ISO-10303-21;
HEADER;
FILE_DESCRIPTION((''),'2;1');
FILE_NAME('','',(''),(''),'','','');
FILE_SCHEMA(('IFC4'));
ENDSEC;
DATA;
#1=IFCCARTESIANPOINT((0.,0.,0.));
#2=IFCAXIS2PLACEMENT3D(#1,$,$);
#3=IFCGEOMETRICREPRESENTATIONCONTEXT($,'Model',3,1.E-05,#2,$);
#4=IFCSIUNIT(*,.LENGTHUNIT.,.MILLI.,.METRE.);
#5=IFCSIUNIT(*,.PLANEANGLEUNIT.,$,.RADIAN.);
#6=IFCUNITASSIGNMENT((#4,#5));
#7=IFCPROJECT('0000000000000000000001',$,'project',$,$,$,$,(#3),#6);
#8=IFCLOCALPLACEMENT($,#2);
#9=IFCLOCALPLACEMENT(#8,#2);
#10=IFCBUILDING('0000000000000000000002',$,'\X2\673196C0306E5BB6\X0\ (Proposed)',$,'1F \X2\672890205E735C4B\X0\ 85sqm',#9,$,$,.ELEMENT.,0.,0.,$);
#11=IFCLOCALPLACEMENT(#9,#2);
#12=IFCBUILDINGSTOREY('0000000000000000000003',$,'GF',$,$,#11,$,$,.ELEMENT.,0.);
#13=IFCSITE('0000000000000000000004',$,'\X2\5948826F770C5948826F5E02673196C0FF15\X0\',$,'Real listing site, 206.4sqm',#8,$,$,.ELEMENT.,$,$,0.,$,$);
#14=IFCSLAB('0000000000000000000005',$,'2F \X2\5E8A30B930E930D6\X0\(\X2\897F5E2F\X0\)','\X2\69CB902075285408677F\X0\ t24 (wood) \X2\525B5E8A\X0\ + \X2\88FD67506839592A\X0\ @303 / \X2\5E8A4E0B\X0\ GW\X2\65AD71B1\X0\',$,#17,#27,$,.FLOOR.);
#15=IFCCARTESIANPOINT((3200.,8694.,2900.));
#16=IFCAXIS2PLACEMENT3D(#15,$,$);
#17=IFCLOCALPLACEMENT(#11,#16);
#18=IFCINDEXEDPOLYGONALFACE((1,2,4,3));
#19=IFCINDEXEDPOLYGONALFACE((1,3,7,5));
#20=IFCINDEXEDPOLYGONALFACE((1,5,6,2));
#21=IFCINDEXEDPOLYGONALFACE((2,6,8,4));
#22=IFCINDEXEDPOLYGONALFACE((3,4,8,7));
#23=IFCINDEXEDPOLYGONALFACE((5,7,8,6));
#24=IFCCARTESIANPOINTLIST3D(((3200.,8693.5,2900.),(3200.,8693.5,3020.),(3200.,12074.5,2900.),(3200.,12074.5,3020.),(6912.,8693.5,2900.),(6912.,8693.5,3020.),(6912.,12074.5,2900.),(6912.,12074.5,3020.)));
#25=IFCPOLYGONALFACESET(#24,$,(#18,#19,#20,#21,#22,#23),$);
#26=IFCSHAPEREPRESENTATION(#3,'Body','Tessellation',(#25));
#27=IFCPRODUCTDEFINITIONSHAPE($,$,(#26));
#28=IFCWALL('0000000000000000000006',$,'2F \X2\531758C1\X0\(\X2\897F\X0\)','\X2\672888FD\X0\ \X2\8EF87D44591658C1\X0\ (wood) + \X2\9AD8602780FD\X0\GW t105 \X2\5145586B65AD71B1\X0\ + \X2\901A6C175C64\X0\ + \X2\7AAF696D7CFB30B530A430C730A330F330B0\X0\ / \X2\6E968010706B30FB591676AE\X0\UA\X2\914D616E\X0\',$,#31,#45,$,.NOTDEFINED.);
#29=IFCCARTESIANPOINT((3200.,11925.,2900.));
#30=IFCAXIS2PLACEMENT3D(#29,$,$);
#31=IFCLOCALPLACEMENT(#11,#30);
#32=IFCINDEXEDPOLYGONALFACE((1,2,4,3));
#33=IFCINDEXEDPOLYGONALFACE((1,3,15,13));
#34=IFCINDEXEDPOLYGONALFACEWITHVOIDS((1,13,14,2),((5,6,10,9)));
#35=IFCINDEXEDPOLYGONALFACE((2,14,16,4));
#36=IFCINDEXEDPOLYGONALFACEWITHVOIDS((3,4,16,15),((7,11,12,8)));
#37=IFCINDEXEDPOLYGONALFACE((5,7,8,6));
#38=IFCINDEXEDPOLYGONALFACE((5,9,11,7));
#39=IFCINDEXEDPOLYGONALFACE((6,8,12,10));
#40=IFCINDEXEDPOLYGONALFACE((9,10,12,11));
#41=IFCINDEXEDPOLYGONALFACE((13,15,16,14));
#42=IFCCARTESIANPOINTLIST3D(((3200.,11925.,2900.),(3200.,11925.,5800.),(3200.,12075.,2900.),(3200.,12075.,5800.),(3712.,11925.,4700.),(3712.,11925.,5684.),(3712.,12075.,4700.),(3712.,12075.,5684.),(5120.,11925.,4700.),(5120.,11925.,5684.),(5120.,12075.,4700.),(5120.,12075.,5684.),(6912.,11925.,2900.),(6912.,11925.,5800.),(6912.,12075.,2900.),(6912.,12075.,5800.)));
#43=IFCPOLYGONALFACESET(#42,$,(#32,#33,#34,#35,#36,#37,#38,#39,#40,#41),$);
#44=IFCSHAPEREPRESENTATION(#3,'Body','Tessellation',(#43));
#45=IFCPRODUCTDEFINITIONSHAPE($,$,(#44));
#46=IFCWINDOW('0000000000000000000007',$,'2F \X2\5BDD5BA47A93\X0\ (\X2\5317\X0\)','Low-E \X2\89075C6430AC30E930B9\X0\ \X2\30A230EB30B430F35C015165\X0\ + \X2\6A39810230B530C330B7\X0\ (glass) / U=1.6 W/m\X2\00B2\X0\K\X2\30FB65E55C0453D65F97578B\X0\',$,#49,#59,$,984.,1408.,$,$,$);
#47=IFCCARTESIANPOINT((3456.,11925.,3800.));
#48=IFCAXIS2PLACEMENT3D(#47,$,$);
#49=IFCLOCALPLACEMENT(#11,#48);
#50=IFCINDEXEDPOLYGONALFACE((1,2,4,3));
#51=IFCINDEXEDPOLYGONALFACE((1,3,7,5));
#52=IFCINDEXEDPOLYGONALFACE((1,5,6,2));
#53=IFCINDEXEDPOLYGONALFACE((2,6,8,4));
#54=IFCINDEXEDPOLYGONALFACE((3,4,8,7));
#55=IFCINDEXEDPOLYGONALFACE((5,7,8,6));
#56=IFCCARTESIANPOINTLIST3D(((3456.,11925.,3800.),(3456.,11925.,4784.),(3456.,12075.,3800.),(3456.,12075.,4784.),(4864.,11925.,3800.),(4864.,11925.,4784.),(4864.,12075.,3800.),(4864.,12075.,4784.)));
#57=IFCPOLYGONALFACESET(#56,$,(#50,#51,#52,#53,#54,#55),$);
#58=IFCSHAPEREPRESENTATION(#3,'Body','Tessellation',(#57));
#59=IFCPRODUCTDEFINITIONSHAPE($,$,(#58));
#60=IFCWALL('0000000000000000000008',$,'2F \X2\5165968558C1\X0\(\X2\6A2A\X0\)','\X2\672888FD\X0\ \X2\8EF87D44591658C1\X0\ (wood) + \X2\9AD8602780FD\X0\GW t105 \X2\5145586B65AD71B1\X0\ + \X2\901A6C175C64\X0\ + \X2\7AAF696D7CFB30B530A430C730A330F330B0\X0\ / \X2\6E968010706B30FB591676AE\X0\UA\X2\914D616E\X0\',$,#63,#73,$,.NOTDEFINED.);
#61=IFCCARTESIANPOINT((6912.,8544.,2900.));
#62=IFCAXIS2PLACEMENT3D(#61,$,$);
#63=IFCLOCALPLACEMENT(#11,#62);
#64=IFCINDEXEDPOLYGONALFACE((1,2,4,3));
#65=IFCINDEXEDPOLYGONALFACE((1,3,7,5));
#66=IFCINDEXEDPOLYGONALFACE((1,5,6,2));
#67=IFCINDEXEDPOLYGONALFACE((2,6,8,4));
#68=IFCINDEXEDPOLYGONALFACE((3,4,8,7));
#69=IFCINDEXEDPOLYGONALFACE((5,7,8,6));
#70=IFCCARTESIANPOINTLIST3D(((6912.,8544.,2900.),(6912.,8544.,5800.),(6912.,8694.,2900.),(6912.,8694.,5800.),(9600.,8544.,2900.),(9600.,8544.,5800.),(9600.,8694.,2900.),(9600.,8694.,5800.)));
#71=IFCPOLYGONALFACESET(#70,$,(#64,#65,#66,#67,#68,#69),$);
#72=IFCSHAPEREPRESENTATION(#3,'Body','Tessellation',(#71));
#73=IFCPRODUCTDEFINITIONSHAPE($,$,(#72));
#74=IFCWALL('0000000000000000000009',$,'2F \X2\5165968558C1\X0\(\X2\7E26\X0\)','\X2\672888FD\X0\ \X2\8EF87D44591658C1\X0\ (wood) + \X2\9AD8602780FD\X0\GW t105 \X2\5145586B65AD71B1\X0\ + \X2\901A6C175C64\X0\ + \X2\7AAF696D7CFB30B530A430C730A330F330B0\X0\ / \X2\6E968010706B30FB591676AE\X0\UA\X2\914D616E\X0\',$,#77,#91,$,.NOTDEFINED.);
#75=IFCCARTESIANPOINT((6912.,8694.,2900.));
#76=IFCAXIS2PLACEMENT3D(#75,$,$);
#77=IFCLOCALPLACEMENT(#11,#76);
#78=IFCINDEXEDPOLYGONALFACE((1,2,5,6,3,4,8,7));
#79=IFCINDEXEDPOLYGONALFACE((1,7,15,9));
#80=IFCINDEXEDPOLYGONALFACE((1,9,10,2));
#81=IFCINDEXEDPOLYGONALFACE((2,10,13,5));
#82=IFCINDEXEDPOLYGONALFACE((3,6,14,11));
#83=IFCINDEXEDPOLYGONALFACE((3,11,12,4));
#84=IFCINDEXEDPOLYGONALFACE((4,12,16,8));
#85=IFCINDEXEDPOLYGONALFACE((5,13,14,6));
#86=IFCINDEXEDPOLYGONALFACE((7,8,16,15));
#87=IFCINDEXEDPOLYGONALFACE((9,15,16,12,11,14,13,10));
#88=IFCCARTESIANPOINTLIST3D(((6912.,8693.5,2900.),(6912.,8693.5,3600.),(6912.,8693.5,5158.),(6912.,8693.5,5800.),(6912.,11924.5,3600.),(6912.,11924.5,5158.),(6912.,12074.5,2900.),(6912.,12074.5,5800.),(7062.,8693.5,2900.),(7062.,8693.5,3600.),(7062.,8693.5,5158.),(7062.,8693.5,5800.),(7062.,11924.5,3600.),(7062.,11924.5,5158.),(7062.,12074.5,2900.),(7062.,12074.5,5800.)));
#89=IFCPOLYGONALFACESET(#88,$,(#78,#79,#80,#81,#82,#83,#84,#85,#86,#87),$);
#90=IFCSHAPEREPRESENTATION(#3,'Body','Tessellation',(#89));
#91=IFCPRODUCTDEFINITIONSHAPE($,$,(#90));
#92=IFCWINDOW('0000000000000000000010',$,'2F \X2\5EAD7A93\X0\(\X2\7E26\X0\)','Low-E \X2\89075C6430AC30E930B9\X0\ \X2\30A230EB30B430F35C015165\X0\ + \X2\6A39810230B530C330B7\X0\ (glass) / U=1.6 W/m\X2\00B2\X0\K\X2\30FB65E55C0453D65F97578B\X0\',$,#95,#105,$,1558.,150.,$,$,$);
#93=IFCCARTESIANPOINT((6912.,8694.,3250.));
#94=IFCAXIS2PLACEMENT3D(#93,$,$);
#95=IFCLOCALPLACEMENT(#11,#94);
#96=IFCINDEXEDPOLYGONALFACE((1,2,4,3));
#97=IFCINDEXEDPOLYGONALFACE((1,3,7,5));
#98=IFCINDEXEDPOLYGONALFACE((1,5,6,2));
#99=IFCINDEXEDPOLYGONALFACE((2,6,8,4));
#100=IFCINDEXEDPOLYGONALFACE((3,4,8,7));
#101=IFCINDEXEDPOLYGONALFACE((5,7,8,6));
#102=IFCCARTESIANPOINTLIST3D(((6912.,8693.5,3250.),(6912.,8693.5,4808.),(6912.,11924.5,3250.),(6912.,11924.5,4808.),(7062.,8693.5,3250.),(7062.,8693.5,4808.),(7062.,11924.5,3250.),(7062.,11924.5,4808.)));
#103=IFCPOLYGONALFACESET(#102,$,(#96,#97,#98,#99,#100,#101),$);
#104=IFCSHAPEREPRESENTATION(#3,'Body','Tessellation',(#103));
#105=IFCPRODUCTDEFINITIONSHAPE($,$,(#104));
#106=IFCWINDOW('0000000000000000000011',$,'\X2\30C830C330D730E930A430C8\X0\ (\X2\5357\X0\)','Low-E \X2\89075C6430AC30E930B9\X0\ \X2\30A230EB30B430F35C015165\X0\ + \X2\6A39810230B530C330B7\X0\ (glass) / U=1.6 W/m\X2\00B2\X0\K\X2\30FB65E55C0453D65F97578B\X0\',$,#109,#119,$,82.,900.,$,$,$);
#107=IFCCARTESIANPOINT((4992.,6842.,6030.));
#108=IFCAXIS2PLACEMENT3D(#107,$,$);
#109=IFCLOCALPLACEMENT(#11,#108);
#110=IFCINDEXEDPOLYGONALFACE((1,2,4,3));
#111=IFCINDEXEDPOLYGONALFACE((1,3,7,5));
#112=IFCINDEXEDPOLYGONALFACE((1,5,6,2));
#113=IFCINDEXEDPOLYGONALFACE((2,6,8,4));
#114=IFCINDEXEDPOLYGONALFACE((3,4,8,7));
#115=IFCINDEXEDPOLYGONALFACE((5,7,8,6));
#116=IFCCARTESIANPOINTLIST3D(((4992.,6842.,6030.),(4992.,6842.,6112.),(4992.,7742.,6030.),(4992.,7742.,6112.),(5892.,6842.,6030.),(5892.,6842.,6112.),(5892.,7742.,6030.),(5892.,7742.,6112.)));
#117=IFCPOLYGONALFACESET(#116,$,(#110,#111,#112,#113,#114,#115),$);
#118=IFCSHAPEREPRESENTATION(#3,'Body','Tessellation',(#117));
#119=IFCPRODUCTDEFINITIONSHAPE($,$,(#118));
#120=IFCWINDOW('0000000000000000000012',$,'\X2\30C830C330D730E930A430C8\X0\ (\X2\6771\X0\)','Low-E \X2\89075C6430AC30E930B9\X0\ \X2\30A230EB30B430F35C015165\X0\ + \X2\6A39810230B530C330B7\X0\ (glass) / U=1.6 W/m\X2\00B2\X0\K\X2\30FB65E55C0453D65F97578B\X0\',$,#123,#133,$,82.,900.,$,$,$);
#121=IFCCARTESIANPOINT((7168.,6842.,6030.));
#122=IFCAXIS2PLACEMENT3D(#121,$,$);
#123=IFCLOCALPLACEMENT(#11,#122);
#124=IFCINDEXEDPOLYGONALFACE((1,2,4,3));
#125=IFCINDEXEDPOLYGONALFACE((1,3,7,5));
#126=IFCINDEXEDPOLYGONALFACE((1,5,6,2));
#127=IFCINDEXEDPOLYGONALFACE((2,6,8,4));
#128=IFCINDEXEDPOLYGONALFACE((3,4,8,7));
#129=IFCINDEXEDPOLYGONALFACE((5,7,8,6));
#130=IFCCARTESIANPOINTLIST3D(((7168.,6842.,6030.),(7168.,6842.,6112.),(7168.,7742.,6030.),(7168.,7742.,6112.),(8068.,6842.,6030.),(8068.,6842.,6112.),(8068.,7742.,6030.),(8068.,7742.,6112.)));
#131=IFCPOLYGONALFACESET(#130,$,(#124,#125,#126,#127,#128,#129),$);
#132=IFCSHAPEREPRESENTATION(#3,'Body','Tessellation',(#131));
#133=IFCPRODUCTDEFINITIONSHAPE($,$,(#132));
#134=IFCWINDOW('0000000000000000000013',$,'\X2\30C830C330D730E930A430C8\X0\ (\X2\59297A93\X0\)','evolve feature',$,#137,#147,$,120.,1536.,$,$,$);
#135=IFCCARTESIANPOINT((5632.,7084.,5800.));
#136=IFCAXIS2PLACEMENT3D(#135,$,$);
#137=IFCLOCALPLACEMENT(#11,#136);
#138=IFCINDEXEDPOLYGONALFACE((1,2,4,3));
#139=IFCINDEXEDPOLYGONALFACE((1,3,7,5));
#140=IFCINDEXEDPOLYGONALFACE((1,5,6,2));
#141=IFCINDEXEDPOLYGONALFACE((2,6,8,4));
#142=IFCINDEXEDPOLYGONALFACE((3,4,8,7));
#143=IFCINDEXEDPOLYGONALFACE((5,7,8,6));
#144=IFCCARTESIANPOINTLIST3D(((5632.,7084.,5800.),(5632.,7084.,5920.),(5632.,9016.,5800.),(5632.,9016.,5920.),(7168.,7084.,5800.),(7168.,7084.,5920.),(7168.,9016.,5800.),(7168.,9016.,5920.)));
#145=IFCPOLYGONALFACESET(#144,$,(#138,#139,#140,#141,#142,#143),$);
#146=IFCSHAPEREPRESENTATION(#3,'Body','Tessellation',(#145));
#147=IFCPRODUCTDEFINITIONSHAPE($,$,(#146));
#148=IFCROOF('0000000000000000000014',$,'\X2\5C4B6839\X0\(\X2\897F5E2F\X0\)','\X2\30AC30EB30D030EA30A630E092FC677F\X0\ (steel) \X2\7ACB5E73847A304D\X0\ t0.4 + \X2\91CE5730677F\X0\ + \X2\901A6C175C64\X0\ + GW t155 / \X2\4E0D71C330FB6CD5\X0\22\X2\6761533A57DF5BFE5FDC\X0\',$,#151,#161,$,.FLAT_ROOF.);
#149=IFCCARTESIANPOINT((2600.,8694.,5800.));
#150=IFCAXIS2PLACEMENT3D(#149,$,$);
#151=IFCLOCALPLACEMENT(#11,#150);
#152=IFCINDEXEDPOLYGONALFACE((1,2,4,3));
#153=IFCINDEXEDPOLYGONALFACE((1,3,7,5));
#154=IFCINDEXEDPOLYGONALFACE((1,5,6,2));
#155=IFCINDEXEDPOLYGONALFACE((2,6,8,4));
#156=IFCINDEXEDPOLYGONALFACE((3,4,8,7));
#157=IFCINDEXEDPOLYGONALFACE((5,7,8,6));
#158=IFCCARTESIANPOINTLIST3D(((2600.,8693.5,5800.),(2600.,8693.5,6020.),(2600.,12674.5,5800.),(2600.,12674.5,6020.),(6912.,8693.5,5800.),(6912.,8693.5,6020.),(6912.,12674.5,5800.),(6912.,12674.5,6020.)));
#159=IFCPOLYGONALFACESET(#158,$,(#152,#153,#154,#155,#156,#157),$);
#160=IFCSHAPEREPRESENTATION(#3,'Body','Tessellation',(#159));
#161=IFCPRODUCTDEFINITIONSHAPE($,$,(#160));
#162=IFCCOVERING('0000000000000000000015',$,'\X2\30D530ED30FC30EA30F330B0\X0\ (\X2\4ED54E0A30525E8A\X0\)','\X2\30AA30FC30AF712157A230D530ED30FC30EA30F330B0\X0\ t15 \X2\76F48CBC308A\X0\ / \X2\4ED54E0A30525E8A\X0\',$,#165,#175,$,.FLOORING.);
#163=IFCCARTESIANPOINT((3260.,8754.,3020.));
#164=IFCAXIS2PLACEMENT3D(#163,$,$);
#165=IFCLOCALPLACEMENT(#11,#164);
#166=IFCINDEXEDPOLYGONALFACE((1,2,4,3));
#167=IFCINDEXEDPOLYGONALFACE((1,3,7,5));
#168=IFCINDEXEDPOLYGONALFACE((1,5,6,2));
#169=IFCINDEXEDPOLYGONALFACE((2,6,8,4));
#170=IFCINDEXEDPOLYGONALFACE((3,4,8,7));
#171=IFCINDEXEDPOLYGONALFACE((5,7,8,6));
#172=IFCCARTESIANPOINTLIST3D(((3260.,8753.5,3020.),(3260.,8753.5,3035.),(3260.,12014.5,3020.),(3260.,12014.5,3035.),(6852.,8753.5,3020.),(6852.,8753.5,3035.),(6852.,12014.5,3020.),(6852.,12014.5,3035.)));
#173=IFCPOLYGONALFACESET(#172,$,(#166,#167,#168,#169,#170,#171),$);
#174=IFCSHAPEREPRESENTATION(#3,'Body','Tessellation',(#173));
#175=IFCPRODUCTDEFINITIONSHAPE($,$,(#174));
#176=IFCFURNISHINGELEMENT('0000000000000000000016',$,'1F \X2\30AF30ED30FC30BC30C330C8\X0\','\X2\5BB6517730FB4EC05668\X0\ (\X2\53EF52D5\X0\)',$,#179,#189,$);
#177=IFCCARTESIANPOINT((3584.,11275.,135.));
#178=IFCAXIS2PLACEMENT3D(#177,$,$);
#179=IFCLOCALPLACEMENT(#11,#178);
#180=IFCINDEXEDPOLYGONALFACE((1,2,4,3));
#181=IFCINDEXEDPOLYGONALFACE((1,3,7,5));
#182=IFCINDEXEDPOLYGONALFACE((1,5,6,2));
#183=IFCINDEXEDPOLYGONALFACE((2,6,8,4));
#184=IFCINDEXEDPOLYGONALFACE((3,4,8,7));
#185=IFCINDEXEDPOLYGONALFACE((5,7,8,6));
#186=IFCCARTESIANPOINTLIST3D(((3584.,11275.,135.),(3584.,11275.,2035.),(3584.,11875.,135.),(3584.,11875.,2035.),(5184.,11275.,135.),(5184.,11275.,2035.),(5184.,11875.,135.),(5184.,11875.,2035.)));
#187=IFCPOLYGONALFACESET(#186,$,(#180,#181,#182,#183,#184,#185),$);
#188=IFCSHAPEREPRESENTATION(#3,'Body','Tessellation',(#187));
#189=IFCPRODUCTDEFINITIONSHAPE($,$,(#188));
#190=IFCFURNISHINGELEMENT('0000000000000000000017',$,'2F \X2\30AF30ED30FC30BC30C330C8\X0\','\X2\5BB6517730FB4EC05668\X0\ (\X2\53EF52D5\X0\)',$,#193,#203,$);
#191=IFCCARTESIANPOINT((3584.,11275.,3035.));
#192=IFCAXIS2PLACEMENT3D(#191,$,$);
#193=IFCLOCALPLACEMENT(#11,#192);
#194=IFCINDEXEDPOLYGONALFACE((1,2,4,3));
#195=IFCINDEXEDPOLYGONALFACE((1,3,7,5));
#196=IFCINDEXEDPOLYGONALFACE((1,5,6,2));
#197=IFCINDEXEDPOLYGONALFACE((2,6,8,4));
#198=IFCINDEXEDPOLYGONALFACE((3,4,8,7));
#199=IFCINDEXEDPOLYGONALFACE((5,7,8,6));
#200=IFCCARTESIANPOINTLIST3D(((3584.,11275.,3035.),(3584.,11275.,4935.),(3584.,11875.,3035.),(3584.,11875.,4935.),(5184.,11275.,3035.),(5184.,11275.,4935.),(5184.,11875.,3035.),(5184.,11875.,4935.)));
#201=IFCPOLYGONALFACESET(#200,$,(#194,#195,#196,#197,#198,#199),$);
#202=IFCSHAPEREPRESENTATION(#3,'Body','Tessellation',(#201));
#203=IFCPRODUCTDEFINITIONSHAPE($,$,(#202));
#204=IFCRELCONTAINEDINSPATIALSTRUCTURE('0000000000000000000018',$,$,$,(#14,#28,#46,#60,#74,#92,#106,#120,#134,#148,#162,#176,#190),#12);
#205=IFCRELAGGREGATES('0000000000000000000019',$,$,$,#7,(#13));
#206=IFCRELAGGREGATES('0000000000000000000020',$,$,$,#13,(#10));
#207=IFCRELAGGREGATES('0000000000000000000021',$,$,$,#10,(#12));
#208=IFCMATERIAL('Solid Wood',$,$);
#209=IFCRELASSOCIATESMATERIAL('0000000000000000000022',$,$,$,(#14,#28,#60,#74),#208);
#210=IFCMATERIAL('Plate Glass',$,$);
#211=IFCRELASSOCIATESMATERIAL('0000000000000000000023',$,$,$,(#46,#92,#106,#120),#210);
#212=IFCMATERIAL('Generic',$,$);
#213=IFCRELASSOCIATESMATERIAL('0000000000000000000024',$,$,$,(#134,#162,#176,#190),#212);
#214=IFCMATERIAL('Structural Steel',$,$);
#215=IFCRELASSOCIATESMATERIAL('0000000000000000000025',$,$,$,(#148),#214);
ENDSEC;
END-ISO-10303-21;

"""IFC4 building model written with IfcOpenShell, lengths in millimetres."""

from ifc_helpers import new_model, si_unit, frame, frame_2d, origin, place, context, project, spatial, rectangle, extrude, material, element, fill, save


model = new_model("IFC4")

# Units and contexts
model_context = context("Model", 3, precision=1e-05, world=origin())
ifc_project = project(units=[si_unit("LENGTHUNIT", "METRE", prefix="MILLI"), si_unit("PLANEANGLEUNIT", "RADIAN")], contexts=[model_context])

# Site, building, storey
site_placement = place(None, origin())
site = spatial("IfcSite", under=ifc_project, at=site_placement, Name="奈良県奈良市朱雀５", ObjectType="Real listing site, 206.4sqm", CompositionType="ELEMENT", RefElevation=0.0)
building_placement = place(site_placement, origin())
building = spatial("IfcBuilding", under=site, at=building_placement, Name="朱雀の家 (Proposed)", ObjectType="1F 木造平屋 85sqm", CompositionType="ELEMENT", ElevationOfRefHeight=0.0, ElevationOfTerrain=0.0)
storey_placement = place(building_placement, origin())
storey = spatial("IfcBuildingStorey", under=building, at=storey_placement, Name="GF", CompositionType="ELEMENT", Elevation=0.0)

# Slab
ifc_material_1 = material(Name="Solid Wood")
slab_placement = place(storey_placement, frame((3200.0, 8694.0, 2900.0)))
element("IfcSlab", 1, at=slab_placement, inside=storey, material=ifc_material_1, Name="2F 床スラブ(西帯)", Description="構造用合板 t24 (wood) 剛床 + 製材根太 @303 / 床下 GW断熱", PredefinedType="FLOOR", context=model_context, shape_type="SweptSolid", body=[
    extrude(rectangle(XDim=3712.0, YDim=3381.0, at=frame_2d((1856.0, 1690.0))), frame((3200.0, 8694.0, 2900.0)), (0.0, 0.0, 1.0), 120.0),
])

# Wall, opening, window
wall_1_placement = place(storey_placement, frame((3200.0, 11925.0, 2900.0)))
wall_1 = element("IfcWall", 2, at=wall_1_placement, inside=storey, material=ifc_material_1, Name="2F 北壁(西)", Description="木製 軸組外壁 (wood) + 高性能GW t105 充填断熱 + 通気層 + 窯業系サイディング / 準耐火・外皮UA配慮", PredefinedType="NOTDEFINED", context=model_context, shape_type="SweptSolid", body=[
    extrude(rectangle(XDim=3712.0, YDim=150.0, at=frame_2d((1856.0, 75.0))), frame((3200.0, 11925.0, 2900.0)), (0.0, 0.0, 1.0), 2900.0),
])
opening_1_placement = place(storey_placement, frame((3456.0, 11925.0, 3800.0)))
opening_1 = element("IfcOpeningElement", 3, at=opening_1_placement, cuts=wall_1, PredefinedType="NOTDEFINED", context=model_context, shape_type="SweptSolid", body=[
    extrude(rectangle(XDim=1408.0, YDim=150.0, at=frame_2d((704.0, 75.0))), frame((3456.0, 11925.0, 3800.0)), (0.0, 0.0, 1.0), 984.0),
])
ifc_material_2 = material(Name="Plate Glass")
window_1_placement = place(storey_placement, frame((3456.0, 11925.0, 3800.0)))
window_1 = element("IfcWindow", 4, at=window_1_placement, inside=storey, material=ifc_material_2, Name="2F 寝室窓 (北)", Description="Low-E 複層ガラス アルゴン封入 + 樹脂サッシ (glass) / U=1.6 W/m²K・日射取得型", OverallHeight=984.0, OverallWidth=1408.0, context=model_context, shape_type="SweptSolid", body=[
    extrude(rectangle(XDim=1408.0, YDim=150.0, at=frame_2d((704.0, 75.0))), frame((3456.0, 11925.0, 3800.0)), (0.0, 0.0, 1.0), 984.0),
])
fill(opening_1, window_1)

# Wall
wall_2_placement = place(storey_placement, frame((6912.0, 8544.0, 2900.0)))
element("IfcWall", 5, at=wall_2_placement, inside=storey, material=ifc_material_1, Name="2F 入隅壁(横)", Description="木製 軸組外壁 (wood) + 高性能GW t105 充填断熱 + 通気層 + 窯業系サイディング / 準耐火・外皮UA配慮", PredefinedType="NOTDEFINED", context=model_context, shape_type="SweptSolid", body=[
    extrude(rectangle(XDim=2688.0, YDim=150.0, at=frame_2d((1344.0, 75.0))), frame((6912.0, 8544.0, 2900.0)), (0.0, 0.0, 1.0), 2900.0),
])

# Wall, opening, window
wall_3_placement = place(storey_placement, frame((6912.0, 8694.0, 2900.0)))
wall_3 = element("IfcWall", 6, at=wall_3_placement, inside=storey, material=ifc_material_1, Name="2F 入隅壁(縦)", Description="木製 軸組外壁 (wood) + 高性能GW t105 充填断熱 + 通気層 + 窯業系サイディング / 準耐火・外皮UA配慮", PredefinedType="NOTDEFINED", context=model_context, shape_type="SweptSolid", body=[
    extrude(rectangle(XDim=150.0, YDim=3381.0, at=frame_2d((75.0, 1690.0))), frame((6912.0, 8694.0, 2900.0)), (0.0, 0.0, 1.0), 2900.0),
])
opening_2_placement = place(storey_placement, frame((6912.0, 8694.0, 3250.0)))
opening_2 = element("IfcOpeningElement", 7, at=opening_2_placement, cuts=wall_3, PredefinedType="NOTDEFINED", context=model_context, shape_type="SweptSolid", body=[
    extrude(rectangle(XDim=150.0, YDim=3231.0, at=frame_2d((75.0, 1615.0))), frame((6912.0, 8694.0, 3250.0)), (0.0, 0.0, 1.0), 1558.0),
])
window_2_placement = place(storey_placement, frame((6912.0, 8694.0, 3250.0)))
window_2 = element("IfcWindow", 8, at=window_2_placement, inside=storey, material=ifc_material_2, Name="2F 庭窓(縦)", Description="Low-E 複層ガラス アルゴン封入 + 樹脂サッシ (glass) / U=1.6 W/m²K・日射取得型", OverallHeight=1558.0, OverallWidth=150.0, context=model_context, shape_type="SweptSolid", body=[
    extrude(rectangle(XDim=150.0, YDim=3231.0, at=frame_2d((75.0, 1615.0))), frame((6912.0, 8694.0, 3250.0)), (0.0, 0.0, 1.0), 1558.0),
])
fill(opening_2, window_2)

# Windows
window_3_placement = place(storey_placement, frame((4992.0, 6842.0, 6030.0)))
element("IfcWindow", 9, at=window_3_placement, inside=storey, material=ifc_material_2, Name="トップライト (南)", Description="Low-E 複層ガラス アルゴン封入 + 樹脂サッシ (glass) / U=1.6 W/m²K・日射取得型", OverallHeight=82.0, OverallWidth=900.0, context=model_context, shape_type="SweptSolid", body=[
    extrude(rectangle(XDim=900.0, YDim=900.0, at=frame_2d((450.0, 450.0))), frame((4992.0, 6842.0, 6030.0)), (0.0, 0.0, 1.0), 82.0),
])
window_4_placement = place(storey_placement, frame((7168.0, 6842.0, 6030.0)))
element("IfcWindow", 10, at=window_4_placement, inside=storey, material=ifc_material_2, Name="トップライト (東)", Description="Low-E 複層ガラス アルゴン封入 + 樹脂サッシ (glass) / U=1.6 W/m²K・日射取得型", OverallHeight=82.0, OverallWidth=900.0, context=model_context, shape_type="SweptSolid", body=[
    extrude(rectangle(XDim=900.0, YDim=900.0, at=frame_2d((450.0, 450.0))), frame((7168.0, 6842.0, 6030.0)), (0.0, 0.0, 1.0), 82.0),
])
ifc_material_3 = material(Name="Generic")
window_5_placement = place(storey_placement, frame((5632.0, 7084.0, 5800.0)))
element("IfcWindow", 11, at=window_5_placement, inside=storey, material=ifc_material_3, Name="トップライト (天窓)", Description="evolve feature", OverallHeight=120.0, OverallWidth=1536.0, context=model_context, shape_type="SweptSolid", body=[
    extrude(rectangle(XDim=1536.0, YDim=1932.0, at=frame_2d((768.0, 966.0))), frame((5632.0, 7084.0, 5800.0)), (0.0, 0.0, 1.0), 120.0),
])

# Roof
ifc_material_4 = material(Name="Structural Steel")
for number, where, name in (
    (12, (2600.0, 8694.0, 5800.0), "屋根(西帯)"),
):
    element("IfcRoof", number, at=place(storey_placement, frame(where)), inside=storey, material=ifc_material_4, Name=name, Description="ガルバリウム鋼板 (steel) 立平葺き t0.4 + 野地板 + 通気層 + GW t155 / 不燃・法22条区域対応", PredefinedType="FLAT_ROOF", context=model_context, shape_type="SweptSolid", body=[
        extrude(rectangle(XDim=4312.0, YDim=3981.0, at=frame_2d((2156.0, 1990.0))), frame((2600.0, 8694.0, 5800.0)), (0.0, 0.0, 1.0), 220.0),
    ])

# Covering
covering_placement = place(storey_placement, frame((3260.0, 8754.0, 3020.0)))
element("IfcCovering", 13, at=covering_placement, inside=storey, material=ifc_material_3, Name="フローリング (仕上げ床)", Description="オーク無垢フローリング t15 直貼り / 仕上げ床", PredefinedType="FLOORING", context=model_context, shape_type="SweptSolid", body=[
    extrude(rectangle(XDim=3592.0, YDim=3261.0, at=frame_2d((1796.0, 1630.0))), frame((3260.0, 8754.0, 3020.0)), (0.0, 0.0, 1.0), 15.0),
])

# Furnishing elements
furnishing_1_placement = place(storey_placement, frame((3584.0, 11275.0, 135.0)))
element("IfcFurnishingElement", 14, at=furnishing_1_placement, inside=storey, material=ifc_material_3, Name="1F クローゼット", Description="家具・什器 (可動)", context=model_context, shape_type="SweptSolid", body=[
    extrude(rectangle(XDim=1600.0, YDim=600.0, at=frame_2d((800.0, 300.0))), frame((3584.0, 11275.0, 135.0)), (0.0, 0.0, 1.0), 1900.0),
])
furnishing_2_placement = place(storey_placement, frame((3584.0, 11275.0, 3035.0)))
element("IfcFurnishingElement", 15, at=furnishing_2_placement, inside=storey, material=ifc_material_3, Name="2F クローゼット", Description="家具・什器 (可動)", context=model_context, shape_type="SweptSolid", body=[
    extrude(rectangle(XDim=1600.0, YDim=600.0, at=frame_2d((800.0, 300.0))), frame((3584.0, 11275.0, 3035.0)), (0.0, 0.0, 1.0), 1900.0),
])

save(model, "model.ifc")
